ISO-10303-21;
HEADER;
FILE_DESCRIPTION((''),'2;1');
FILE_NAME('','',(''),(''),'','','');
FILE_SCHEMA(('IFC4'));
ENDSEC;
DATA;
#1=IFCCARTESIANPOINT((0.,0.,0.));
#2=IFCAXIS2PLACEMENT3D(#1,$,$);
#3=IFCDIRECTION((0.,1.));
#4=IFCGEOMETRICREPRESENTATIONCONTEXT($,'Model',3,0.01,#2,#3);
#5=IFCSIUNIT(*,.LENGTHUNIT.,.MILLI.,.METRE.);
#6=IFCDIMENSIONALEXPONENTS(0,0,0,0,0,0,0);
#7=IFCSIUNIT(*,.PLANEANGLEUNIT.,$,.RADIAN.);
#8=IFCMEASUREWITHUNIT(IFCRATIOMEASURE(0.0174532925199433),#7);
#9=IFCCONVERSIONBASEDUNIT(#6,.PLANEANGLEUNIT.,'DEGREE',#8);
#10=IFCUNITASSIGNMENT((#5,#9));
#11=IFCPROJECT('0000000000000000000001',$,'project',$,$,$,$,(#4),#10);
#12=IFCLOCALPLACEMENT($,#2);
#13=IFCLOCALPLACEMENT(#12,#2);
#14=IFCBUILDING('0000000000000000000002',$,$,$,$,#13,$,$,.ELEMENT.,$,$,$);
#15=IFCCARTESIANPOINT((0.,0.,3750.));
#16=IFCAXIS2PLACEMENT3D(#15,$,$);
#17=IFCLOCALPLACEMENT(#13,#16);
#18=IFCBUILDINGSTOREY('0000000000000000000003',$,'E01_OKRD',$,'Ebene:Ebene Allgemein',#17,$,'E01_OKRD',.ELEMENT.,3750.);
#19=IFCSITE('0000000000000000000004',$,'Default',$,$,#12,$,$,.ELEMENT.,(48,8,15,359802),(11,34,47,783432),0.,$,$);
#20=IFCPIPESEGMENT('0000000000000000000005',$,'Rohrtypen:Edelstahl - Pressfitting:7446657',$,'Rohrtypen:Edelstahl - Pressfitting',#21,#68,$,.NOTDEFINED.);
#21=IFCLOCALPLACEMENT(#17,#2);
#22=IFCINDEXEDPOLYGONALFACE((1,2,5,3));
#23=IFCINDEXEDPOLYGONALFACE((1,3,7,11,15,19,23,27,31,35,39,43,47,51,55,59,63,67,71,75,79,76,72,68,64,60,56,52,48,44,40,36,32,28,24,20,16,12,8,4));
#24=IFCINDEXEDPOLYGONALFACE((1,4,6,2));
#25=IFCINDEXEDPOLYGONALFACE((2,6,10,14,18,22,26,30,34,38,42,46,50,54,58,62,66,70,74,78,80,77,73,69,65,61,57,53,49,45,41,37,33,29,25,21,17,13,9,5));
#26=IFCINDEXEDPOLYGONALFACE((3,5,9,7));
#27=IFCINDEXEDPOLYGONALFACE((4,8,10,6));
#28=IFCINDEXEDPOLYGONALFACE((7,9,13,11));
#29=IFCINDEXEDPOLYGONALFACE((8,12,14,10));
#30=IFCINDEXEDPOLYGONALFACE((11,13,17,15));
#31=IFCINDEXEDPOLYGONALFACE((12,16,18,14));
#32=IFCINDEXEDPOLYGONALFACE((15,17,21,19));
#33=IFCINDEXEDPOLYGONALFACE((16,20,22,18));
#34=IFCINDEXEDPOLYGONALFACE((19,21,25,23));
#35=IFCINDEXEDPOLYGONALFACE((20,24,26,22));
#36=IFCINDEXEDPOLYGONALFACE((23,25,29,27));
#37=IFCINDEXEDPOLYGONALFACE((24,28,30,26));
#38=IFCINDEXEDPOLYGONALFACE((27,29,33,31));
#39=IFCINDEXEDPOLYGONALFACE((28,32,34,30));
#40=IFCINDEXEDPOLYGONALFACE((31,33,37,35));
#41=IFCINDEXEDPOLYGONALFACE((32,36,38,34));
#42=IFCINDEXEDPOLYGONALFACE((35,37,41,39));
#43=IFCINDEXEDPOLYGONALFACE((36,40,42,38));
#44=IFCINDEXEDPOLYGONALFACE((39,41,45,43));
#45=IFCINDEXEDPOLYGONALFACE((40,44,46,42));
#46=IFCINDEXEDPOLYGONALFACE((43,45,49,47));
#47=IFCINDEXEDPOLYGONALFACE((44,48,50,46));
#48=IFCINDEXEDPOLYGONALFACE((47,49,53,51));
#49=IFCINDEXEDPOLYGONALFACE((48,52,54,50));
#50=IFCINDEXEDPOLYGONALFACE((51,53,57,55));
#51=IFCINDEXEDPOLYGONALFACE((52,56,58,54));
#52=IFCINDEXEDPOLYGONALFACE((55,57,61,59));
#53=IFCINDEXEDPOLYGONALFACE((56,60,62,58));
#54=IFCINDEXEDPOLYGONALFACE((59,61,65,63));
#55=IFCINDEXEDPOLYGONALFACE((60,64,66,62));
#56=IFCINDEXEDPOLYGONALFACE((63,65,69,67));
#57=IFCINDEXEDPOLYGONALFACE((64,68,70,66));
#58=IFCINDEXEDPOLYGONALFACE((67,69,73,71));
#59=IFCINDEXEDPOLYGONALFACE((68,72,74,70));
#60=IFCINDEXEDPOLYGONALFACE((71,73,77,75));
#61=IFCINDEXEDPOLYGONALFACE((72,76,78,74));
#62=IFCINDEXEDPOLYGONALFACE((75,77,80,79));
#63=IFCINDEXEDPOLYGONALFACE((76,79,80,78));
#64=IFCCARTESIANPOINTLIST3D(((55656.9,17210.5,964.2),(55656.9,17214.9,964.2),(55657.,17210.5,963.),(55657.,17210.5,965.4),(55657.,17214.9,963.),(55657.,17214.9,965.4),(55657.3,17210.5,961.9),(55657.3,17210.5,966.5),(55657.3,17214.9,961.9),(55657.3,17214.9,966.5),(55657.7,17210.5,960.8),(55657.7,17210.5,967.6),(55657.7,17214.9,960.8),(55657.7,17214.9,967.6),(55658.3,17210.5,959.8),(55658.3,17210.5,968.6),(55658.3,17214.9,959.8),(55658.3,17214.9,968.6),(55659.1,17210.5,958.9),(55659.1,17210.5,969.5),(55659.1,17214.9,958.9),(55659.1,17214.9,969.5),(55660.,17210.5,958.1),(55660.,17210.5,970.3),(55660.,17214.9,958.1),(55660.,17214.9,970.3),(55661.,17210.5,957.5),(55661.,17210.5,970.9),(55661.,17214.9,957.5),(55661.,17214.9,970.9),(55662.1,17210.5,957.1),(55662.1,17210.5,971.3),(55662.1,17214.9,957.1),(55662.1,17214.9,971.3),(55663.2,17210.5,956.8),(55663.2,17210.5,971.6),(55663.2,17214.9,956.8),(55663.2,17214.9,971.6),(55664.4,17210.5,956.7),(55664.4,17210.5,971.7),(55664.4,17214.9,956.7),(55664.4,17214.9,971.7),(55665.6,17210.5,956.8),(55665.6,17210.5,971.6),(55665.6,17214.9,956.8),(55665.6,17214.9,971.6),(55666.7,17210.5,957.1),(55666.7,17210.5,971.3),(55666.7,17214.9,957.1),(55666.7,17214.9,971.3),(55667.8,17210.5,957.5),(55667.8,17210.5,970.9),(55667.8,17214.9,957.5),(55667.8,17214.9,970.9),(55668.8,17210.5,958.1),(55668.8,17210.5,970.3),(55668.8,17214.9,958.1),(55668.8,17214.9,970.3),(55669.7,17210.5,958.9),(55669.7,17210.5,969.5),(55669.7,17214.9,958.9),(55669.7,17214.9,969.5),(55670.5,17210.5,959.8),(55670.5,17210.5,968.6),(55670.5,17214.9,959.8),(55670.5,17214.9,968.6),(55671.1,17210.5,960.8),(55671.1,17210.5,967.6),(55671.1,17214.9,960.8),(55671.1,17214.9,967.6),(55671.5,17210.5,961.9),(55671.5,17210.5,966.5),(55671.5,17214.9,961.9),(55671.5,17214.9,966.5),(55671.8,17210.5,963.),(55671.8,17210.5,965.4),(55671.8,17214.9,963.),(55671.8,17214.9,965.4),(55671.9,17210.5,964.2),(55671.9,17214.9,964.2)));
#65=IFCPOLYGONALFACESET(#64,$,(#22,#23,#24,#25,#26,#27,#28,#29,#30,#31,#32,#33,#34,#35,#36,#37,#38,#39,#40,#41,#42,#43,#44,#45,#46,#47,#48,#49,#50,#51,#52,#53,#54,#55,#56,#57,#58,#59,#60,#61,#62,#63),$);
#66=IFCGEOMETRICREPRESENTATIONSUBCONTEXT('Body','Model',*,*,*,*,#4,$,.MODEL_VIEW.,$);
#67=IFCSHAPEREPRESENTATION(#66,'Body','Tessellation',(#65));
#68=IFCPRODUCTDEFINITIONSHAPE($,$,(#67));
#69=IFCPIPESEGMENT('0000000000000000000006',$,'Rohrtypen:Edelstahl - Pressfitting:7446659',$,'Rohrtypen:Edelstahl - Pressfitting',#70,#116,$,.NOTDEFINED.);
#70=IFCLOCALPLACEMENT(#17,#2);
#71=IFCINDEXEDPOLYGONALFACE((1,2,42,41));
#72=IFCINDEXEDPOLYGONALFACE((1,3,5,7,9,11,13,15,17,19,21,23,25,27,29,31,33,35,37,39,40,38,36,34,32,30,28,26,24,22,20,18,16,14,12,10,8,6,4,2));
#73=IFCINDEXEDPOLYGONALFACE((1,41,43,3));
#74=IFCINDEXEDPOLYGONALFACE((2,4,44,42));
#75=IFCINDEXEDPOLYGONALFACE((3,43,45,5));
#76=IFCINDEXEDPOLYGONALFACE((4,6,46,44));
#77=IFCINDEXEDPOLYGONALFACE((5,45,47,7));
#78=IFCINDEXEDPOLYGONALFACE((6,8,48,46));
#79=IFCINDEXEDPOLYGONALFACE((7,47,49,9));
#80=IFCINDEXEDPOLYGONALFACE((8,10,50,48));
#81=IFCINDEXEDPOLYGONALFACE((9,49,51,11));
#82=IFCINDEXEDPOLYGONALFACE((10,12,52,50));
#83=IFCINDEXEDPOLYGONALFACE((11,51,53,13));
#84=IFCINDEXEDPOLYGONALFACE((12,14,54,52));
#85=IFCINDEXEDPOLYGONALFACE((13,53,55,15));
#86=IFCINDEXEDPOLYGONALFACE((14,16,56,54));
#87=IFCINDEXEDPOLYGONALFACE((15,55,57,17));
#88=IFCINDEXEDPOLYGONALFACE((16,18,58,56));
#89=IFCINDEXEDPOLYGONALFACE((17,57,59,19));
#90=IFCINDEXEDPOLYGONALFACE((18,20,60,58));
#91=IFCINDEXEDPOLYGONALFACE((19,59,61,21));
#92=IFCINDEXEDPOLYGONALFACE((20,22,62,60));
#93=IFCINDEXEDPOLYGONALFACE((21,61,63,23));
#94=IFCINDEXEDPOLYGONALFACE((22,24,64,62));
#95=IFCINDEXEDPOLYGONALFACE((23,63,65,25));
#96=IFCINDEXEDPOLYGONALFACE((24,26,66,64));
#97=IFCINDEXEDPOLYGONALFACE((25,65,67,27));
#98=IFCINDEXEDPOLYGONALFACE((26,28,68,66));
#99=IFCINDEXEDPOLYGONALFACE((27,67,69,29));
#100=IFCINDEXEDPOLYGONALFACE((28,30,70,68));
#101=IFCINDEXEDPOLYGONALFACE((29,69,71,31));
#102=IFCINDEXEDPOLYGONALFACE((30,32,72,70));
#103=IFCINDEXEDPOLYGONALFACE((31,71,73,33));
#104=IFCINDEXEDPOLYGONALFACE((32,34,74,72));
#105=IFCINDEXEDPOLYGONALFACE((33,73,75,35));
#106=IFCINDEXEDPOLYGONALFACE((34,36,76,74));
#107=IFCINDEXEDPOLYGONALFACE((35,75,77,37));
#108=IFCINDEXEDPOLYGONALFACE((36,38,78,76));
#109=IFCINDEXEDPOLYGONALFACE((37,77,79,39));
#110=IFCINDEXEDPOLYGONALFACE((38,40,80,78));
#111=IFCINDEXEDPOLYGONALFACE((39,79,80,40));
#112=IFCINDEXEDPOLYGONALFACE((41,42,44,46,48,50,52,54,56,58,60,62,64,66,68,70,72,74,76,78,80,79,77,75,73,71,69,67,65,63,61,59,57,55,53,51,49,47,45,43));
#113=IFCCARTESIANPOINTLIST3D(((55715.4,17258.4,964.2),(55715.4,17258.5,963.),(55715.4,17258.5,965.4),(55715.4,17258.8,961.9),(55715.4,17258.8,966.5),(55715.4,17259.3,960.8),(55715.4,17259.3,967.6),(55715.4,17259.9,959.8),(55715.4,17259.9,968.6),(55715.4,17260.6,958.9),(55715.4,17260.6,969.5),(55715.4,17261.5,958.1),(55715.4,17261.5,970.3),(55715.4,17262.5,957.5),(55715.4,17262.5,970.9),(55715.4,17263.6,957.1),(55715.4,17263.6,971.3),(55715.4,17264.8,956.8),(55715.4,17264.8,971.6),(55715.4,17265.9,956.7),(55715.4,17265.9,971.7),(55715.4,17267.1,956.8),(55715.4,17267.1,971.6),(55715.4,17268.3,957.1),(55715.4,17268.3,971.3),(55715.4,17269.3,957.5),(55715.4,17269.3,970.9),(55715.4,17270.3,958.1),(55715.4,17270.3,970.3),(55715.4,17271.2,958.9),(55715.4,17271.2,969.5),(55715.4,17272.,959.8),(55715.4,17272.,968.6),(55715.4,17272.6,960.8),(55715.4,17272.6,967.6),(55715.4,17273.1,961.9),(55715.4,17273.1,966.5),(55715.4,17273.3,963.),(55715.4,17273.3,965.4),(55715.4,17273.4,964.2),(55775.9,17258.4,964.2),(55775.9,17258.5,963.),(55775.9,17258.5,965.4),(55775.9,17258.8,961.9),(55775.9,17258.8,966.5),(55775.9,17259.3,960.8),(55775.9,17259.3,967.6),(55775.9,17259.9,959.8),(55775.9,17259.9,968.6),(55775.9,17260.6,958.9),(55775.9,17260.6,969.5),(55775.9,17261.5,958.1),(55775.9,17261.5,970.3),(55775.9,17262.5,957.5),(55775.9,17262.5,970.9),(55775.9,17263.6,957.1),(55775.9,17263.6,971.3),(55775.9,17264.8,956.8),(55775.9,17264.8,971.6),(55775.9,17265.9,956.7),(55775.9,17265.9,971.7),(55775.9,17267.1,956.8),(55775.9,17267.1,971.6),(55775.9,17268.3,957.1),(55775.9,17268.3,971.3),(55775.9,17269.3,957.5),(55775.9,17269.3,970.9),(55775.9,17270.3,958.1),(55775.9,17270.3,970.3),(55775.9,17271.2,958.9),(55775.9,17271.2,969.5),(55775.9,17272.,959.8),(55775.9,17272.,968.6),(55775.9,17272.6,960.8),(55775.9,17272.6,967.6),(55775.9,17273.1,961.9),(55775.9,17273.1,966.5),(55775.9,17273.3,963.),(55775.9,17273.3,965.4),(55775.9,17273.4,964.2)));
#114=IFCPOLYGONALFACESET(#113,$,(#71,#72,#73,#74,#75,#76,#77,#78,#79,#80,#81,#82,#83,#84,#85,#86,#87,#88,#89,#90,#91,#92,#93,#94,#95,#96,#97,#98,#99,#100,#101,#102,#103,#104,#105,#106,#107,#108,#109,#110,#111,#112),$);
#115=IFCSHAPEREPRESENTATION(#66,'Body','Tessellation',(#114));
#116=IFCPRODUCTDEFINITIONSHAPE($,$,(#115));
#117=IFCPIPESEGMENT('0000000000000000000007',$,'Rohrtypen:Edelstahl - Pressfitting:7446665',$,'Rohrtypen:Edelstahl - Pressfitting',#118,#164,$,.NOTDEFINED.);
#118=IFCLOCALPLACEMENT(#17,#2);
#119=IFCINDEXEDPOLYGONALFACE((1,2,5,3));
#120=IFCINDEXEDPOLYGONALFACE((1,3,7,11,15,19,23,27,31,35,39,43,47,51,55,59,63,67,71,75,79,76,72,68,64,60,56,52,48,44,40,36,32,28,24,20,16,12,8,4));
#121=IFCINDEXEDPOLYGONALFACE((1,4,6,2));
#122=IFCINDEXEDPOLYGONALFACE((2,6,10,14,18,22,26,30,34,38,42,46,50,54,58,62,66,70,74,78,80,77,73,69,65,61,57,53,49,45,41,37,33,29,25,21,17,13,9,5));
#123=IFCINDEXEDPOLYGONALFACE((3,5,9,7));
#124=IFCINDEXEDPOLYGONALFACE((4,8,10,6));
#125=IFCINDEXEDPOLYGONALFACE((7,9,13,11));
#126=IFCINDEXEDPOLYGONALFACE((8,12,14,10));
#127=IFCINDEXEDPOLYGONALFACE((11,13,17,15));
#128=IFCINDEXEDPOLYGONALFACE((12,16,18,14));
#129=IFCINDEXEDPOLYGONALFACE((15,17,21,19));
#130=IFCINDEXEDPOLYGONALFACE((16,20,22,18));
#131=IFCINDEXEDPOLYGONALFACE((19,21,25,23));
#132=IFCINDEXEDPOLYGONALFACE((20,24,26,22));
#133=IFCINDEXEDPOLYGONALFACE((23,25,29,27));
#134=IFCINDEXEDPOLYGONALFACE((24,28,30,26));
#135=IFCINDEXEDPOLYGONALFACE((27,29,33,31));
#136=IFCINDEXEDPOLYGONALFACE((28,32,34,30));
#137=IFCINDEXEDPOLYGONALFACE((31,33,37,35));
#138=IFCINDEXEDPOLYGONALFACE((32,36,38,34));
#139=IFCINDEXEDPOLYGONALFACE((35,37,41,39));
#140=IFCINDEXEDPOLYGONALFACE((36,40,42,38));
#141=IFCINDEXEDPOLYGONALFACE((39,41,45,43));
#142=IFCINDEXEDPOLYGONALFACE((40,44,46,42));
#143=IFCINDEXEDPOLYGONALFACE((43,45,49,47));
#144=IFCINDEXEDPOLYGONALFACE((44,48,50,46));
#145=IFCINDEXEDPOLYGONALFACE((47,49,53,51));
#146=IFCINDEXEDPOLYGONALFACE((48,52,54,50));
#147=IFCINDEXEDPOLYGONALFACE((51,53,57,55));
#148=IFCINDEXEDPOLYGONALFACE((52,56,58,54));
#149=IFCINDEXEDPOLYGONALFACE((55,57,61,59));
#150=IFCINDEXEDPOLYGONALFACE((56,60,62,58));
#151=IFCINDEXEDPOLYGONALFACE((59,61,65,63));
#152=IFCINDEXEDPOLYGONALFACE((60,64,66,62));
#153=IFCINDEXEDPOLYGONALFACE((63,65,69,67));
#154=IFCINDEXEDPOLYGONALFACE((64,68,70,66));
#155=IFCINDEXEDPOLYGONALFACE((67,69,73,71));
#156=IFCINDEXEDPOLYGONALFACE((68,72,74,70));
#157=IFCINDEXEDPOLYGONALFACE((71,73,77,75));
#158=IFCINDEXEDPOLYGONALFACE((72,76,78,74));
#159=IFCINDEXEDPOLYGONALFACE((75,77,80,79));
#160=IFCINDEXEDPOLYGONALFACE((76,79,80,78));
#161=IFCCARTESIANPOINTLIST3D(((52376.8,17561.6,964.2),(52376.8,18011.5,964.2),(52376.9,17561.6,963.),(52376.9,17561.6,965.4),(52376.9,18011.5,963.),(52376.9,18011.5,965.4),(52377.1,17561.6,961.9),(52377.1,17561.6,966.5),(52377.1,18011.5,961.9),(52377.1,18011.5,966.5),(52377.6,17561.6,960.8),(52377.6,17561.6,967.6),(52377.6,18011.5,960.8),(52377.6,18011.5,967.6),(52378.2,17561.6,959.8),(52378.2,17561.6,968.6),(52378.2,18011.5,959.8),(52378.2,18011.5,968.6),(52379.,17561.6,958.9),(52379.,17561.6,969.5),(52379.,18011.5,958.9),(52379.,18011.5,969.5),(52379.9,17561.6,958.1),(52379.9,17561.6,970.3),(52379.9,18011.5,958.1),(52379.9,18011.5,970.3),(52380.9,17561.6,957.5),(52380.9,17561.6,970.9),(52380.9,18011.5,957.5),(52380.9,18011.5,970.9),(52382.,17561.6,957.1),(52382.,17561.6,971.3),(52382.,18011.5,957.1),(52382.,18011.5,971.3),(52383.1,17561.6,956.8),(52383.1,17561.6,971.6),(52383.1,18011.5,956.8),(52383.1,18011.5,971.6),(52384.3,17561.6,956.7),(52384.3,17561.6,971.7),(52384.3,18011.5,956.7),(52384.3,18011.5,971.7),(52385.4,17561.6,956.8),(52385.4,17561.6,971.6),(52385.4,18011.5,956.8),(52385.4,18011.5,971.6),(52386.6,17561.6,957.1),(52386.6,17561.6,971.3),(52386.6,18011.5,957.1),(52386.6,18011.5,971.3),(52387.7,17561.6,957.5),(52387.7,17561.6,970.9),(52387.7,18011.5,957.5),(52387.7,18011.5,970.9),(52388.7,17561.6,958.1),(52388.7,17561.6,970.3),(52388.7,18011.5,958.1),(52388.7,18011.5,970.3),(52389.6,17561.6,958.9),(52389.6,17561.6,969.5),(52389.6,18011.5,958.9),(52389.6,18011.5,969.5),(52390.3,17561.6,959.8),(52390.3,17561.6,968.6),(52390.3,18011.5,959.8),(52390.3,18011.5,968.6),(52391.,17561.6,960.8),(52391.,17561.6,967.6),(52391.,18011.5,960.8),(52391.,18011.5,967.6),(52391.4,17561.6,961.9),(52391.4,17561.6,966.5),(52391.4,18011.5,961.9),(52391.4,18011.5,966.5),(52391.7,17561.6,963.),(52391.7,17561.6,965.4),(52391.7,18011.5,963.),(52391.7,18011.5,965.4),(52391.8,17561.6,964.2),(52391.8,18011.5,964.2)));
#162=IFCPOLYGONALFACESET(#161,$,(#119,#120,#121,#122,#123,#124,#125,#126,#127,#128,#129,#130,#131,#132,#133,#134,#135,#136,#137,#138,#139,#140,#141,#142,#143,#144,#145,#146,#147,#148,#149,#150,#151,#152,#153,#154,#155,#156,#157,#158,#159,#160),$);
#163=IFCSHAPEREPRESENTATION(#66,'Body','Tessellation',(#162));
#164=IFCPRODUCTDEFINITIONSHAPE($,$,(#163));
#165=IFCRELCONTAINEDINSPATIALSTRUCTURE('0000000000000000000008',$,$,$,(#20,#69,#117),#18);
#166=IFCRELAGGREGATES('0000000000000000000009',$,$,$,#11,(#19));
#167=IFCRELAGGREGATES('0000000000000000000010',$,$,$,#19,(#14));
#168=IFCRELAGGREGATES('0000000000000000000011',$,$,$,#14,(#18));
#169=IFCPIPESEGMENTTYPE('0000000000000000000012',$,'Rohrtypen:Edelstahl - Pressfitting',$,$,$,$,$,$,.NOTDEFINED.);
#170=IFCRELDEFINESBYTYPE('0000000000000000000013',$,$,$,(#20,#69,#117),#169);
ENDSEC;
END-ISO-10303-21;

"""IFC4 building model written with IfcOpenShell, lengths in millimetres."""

from ifc_helpers import new_model, entity, si_unit, converted_unit, direction, frame, origin, place, context, subcontext, project, spatial, indexed_curve, outline, extrude, type_object, element, save


model = new_model("IFC4")

# Units and contexts
model_context = context("Model", 3, precision=0.01, world=origin(), true_north=direction((0.0, 1.0)))
body_context = subcontext(model_context, "Body", "Model", "MODEL_VIEW")
ifc_project = project(units=[si_unit("LENGTHUNIT", "METRE", prefix="MILLI"), converted_unit("PLANEANGLEUNIT", "DEGREE", entity("IfcRatioMeasure", 0.0174532925199433), si_unit("PLANEANGLEUNIT", "RADIAN"), dimensions=[0, 0, 0, 0, 0, 0, 0])], contexts=[model_context])

# Site, building, storey
site_placement = place(None, origin())
site = spatial("IfcSite", under=ifc_project, at=site_placement, Name="Default", CompositionType="ELEMENT", RefLatitude=(48, 8, 15, 359802), RefLongitude=(11, 34, 47, 783432), RefElevation=0.0)
building_placement = place(site_placement, origin())
building = spatial("IfcBuilding", under=site, at=building_placement, CompositionType="ELEMENT")
storey_placement = place(building_placement, frame((0.0, 0.0, 3750.0)))
storey = spatial("IfcBuildingStorey", under=building, at=storey_placement, Name="E01_OKRD", ObjectType="Ebene:Ebene Allgemein", LongName="E01_OKRD", CompositionType="ELEMENT", Elevation=3750.0)

# Pipe segments
pipe_segment_type_1 = type_object("IfcPipeSegmentType", Name="Rohrtypen:Edelstahl - Pressfitting", PredefinedType="NOTDEFINED")
pipe_segment_1_placement = place(storey_placement, origin())
element("IfcPipeSegment", 1, at=pipe_segment_1_placement, inside=storey, type_object=pipe_segment_type_1, Name="Rohrtypen:Edelstahl - Pressfitting:7446657", ObjectType="Rohrtypen:Edelstahl - Pressfitting", PredefinedType="NOTDEFINED", context=body_context, shape_type="SweptSolid", body=[
    extrude(outline(indexed_curve([(7.5, 0.0), (7.4, 1.2), (7.1, 2.3), (6.7, 3.4), (6.1, 4.4), (5.3, 5.3), (4.4, 6.1), (3.4, 6.7), (2.3, 7.1), (1.2, 7.4), (0.0, 7.5), (-1.2, 7.4), (-2.3, 7.1), (-3.4, 6.7), (-4.4, 6.1), (-5.3, 5.3), (-6.1, 4.4), (-6.7, 3.4), (-7.1, 2.3), (-7.4, 1.2), (-7.5, 0.0), (-7.4, -1.2), (-7.1, -2.3), (-6.7, -3.4), (-6.1, -4.4), (-5.3, -5.3), (-4.4, -6.1), (-3.4, -6.7), (-2.3, -7.1), (-1.2, -7.4), (0.0, -7.5), (1.2, -7.4), (2.3, -7.1), (3.4, -6.7), (4.4, -6.1), (5.3, -5.3), (6.1, -4.4), (6.7, -3.4), (7.1, -2.3), (7.4, -1.2), (7.5, 0.0)], self_intersect=False)), frame((55664.4, 17210.5, 964.2), z_axis=(0.0, 1.0, 0.0), x_axis=(1.0, 0.0, 0.0)), (0.0, 0.0, 1.0), 4.4),
])
pipe_segment_2_placement = place(storey_placement, origin())
element("IfcPipeSegment", 2, at=pipe_segment_2_placement, inside=storey, type_object=pipe_segment_type_1, Name="Rohrtypen:Edelstahl - Pressfitting:7446659", ObjectType="Rohrtypen:Edelstahl - Pressfitting", PredefinedType="NOTDEFINED", context=body_context, shape_type="SweptSolid", body=[
    extrude(outline(indexed_curve([(7.5, 0.0), (7.4, 1.2), (7.1, 2.3), (6.7, 3.4), (6.1, 4.4), (5.3, 5.3), (4.4, 6.1), (3.4, 6.7), (2.3, 7.1), (1.2, 7.4), (0.0, 7.5), (-1.2, 7.4), (-2.3, 7.1), (-3.4, 6.7), (-4.4, 6.1), (-5.3, 5.3), (-6.1, 4.4), (-6.7, 3.4), (-7.1, 2.3), (-7.4, 1.2), (-7.5, 0.0), (-7.4, -1.2), (-7.1, -2.3), (-6.7, -3.4), (-6.1, -4.4), (-5.3, -5.3), (-4.4, -6.1), (-3.4, -6.7), (-2.3, -7.1), (-1.2, -7.4), (0.0, -7.5), (1.2, -7.4), (2.3, -7.1), (3.4, -6.7), (4.4, -6.1), (5.3, -5.3), (6.1, -4.4), (6.7, -3.4), (7.1, -2.3), (7.4, -1.2), (7.5, 0.0)], self_intersect=False)), frame((55715.4, 17265.9, 964.2), z_axis=(1.0, 0.0, -0.000221), x_axis=(0.0, 1.0, 0.0)), (0.0, 0.0, 1.0), 60.5),
])
pipe_segment_3_placement = place(storey_placement, origin())
element("IfcPipeSegment", 3, at=pipe_segment_3_placement, inside=storey, type_object=pipe_segment_type_1, Name="Rohrtypen:Edelstahl - Pressfitting:7446665", ObjectType="Rohrtypen:Edelstahl - Pressfitting", PredefinedType="NOTDEFINED", context=body_context, shape_type="SweptSolid", body=[
    extrude(outline(indexed_curve([(7.5, 0.0), (7.4, 1.2), (7.1, 2.3), (6.7, 3.4), (6.1, 4.4), (5.3, 5.3), (4.4, 6.1), (3.4, 6.7), (2.3, 7.1), (1.2, 7.4), (0.0, 7.5), (-1.2, 7.4), (-2.3, 7.1), (-3.4, 6.7), (-4.4, 6.1), (-5.3, 5.3), (-6.1, 4.4), (-6.7, 3.4), (-7.1, 2.3), (-7.4, 1.2), (-7.5, 0.0), (-7.4, -1.2), (-7.1, -2.3), (-6.7, -3.4), (-6.1, -4.4), (-5.3, -5.3), (-4.4, -6.1), (-3.4, -6.7), (-2.3, -7.1), (-1.2, -7.4), (0.0, -7.5), (1.2, -7.4), (2.3, -7.1), (3.4, -6.7), (4.4, -6.1), (5.3, -5.3), (6.1, -4.4), (6.7, -3.4), (7.1, -2.3), (7.4, -1.2), (7.5, 0.0)], self_intersect=False)), frame((52384.3, 17561.6, 964.2), z_axis=(0.000013, 1.0, 0.0), x_axis=(1.0, -0.000013, 0.0)), (0.0, 0.0, 1.0), 450.0),
])

save(model, "model.ifc")
